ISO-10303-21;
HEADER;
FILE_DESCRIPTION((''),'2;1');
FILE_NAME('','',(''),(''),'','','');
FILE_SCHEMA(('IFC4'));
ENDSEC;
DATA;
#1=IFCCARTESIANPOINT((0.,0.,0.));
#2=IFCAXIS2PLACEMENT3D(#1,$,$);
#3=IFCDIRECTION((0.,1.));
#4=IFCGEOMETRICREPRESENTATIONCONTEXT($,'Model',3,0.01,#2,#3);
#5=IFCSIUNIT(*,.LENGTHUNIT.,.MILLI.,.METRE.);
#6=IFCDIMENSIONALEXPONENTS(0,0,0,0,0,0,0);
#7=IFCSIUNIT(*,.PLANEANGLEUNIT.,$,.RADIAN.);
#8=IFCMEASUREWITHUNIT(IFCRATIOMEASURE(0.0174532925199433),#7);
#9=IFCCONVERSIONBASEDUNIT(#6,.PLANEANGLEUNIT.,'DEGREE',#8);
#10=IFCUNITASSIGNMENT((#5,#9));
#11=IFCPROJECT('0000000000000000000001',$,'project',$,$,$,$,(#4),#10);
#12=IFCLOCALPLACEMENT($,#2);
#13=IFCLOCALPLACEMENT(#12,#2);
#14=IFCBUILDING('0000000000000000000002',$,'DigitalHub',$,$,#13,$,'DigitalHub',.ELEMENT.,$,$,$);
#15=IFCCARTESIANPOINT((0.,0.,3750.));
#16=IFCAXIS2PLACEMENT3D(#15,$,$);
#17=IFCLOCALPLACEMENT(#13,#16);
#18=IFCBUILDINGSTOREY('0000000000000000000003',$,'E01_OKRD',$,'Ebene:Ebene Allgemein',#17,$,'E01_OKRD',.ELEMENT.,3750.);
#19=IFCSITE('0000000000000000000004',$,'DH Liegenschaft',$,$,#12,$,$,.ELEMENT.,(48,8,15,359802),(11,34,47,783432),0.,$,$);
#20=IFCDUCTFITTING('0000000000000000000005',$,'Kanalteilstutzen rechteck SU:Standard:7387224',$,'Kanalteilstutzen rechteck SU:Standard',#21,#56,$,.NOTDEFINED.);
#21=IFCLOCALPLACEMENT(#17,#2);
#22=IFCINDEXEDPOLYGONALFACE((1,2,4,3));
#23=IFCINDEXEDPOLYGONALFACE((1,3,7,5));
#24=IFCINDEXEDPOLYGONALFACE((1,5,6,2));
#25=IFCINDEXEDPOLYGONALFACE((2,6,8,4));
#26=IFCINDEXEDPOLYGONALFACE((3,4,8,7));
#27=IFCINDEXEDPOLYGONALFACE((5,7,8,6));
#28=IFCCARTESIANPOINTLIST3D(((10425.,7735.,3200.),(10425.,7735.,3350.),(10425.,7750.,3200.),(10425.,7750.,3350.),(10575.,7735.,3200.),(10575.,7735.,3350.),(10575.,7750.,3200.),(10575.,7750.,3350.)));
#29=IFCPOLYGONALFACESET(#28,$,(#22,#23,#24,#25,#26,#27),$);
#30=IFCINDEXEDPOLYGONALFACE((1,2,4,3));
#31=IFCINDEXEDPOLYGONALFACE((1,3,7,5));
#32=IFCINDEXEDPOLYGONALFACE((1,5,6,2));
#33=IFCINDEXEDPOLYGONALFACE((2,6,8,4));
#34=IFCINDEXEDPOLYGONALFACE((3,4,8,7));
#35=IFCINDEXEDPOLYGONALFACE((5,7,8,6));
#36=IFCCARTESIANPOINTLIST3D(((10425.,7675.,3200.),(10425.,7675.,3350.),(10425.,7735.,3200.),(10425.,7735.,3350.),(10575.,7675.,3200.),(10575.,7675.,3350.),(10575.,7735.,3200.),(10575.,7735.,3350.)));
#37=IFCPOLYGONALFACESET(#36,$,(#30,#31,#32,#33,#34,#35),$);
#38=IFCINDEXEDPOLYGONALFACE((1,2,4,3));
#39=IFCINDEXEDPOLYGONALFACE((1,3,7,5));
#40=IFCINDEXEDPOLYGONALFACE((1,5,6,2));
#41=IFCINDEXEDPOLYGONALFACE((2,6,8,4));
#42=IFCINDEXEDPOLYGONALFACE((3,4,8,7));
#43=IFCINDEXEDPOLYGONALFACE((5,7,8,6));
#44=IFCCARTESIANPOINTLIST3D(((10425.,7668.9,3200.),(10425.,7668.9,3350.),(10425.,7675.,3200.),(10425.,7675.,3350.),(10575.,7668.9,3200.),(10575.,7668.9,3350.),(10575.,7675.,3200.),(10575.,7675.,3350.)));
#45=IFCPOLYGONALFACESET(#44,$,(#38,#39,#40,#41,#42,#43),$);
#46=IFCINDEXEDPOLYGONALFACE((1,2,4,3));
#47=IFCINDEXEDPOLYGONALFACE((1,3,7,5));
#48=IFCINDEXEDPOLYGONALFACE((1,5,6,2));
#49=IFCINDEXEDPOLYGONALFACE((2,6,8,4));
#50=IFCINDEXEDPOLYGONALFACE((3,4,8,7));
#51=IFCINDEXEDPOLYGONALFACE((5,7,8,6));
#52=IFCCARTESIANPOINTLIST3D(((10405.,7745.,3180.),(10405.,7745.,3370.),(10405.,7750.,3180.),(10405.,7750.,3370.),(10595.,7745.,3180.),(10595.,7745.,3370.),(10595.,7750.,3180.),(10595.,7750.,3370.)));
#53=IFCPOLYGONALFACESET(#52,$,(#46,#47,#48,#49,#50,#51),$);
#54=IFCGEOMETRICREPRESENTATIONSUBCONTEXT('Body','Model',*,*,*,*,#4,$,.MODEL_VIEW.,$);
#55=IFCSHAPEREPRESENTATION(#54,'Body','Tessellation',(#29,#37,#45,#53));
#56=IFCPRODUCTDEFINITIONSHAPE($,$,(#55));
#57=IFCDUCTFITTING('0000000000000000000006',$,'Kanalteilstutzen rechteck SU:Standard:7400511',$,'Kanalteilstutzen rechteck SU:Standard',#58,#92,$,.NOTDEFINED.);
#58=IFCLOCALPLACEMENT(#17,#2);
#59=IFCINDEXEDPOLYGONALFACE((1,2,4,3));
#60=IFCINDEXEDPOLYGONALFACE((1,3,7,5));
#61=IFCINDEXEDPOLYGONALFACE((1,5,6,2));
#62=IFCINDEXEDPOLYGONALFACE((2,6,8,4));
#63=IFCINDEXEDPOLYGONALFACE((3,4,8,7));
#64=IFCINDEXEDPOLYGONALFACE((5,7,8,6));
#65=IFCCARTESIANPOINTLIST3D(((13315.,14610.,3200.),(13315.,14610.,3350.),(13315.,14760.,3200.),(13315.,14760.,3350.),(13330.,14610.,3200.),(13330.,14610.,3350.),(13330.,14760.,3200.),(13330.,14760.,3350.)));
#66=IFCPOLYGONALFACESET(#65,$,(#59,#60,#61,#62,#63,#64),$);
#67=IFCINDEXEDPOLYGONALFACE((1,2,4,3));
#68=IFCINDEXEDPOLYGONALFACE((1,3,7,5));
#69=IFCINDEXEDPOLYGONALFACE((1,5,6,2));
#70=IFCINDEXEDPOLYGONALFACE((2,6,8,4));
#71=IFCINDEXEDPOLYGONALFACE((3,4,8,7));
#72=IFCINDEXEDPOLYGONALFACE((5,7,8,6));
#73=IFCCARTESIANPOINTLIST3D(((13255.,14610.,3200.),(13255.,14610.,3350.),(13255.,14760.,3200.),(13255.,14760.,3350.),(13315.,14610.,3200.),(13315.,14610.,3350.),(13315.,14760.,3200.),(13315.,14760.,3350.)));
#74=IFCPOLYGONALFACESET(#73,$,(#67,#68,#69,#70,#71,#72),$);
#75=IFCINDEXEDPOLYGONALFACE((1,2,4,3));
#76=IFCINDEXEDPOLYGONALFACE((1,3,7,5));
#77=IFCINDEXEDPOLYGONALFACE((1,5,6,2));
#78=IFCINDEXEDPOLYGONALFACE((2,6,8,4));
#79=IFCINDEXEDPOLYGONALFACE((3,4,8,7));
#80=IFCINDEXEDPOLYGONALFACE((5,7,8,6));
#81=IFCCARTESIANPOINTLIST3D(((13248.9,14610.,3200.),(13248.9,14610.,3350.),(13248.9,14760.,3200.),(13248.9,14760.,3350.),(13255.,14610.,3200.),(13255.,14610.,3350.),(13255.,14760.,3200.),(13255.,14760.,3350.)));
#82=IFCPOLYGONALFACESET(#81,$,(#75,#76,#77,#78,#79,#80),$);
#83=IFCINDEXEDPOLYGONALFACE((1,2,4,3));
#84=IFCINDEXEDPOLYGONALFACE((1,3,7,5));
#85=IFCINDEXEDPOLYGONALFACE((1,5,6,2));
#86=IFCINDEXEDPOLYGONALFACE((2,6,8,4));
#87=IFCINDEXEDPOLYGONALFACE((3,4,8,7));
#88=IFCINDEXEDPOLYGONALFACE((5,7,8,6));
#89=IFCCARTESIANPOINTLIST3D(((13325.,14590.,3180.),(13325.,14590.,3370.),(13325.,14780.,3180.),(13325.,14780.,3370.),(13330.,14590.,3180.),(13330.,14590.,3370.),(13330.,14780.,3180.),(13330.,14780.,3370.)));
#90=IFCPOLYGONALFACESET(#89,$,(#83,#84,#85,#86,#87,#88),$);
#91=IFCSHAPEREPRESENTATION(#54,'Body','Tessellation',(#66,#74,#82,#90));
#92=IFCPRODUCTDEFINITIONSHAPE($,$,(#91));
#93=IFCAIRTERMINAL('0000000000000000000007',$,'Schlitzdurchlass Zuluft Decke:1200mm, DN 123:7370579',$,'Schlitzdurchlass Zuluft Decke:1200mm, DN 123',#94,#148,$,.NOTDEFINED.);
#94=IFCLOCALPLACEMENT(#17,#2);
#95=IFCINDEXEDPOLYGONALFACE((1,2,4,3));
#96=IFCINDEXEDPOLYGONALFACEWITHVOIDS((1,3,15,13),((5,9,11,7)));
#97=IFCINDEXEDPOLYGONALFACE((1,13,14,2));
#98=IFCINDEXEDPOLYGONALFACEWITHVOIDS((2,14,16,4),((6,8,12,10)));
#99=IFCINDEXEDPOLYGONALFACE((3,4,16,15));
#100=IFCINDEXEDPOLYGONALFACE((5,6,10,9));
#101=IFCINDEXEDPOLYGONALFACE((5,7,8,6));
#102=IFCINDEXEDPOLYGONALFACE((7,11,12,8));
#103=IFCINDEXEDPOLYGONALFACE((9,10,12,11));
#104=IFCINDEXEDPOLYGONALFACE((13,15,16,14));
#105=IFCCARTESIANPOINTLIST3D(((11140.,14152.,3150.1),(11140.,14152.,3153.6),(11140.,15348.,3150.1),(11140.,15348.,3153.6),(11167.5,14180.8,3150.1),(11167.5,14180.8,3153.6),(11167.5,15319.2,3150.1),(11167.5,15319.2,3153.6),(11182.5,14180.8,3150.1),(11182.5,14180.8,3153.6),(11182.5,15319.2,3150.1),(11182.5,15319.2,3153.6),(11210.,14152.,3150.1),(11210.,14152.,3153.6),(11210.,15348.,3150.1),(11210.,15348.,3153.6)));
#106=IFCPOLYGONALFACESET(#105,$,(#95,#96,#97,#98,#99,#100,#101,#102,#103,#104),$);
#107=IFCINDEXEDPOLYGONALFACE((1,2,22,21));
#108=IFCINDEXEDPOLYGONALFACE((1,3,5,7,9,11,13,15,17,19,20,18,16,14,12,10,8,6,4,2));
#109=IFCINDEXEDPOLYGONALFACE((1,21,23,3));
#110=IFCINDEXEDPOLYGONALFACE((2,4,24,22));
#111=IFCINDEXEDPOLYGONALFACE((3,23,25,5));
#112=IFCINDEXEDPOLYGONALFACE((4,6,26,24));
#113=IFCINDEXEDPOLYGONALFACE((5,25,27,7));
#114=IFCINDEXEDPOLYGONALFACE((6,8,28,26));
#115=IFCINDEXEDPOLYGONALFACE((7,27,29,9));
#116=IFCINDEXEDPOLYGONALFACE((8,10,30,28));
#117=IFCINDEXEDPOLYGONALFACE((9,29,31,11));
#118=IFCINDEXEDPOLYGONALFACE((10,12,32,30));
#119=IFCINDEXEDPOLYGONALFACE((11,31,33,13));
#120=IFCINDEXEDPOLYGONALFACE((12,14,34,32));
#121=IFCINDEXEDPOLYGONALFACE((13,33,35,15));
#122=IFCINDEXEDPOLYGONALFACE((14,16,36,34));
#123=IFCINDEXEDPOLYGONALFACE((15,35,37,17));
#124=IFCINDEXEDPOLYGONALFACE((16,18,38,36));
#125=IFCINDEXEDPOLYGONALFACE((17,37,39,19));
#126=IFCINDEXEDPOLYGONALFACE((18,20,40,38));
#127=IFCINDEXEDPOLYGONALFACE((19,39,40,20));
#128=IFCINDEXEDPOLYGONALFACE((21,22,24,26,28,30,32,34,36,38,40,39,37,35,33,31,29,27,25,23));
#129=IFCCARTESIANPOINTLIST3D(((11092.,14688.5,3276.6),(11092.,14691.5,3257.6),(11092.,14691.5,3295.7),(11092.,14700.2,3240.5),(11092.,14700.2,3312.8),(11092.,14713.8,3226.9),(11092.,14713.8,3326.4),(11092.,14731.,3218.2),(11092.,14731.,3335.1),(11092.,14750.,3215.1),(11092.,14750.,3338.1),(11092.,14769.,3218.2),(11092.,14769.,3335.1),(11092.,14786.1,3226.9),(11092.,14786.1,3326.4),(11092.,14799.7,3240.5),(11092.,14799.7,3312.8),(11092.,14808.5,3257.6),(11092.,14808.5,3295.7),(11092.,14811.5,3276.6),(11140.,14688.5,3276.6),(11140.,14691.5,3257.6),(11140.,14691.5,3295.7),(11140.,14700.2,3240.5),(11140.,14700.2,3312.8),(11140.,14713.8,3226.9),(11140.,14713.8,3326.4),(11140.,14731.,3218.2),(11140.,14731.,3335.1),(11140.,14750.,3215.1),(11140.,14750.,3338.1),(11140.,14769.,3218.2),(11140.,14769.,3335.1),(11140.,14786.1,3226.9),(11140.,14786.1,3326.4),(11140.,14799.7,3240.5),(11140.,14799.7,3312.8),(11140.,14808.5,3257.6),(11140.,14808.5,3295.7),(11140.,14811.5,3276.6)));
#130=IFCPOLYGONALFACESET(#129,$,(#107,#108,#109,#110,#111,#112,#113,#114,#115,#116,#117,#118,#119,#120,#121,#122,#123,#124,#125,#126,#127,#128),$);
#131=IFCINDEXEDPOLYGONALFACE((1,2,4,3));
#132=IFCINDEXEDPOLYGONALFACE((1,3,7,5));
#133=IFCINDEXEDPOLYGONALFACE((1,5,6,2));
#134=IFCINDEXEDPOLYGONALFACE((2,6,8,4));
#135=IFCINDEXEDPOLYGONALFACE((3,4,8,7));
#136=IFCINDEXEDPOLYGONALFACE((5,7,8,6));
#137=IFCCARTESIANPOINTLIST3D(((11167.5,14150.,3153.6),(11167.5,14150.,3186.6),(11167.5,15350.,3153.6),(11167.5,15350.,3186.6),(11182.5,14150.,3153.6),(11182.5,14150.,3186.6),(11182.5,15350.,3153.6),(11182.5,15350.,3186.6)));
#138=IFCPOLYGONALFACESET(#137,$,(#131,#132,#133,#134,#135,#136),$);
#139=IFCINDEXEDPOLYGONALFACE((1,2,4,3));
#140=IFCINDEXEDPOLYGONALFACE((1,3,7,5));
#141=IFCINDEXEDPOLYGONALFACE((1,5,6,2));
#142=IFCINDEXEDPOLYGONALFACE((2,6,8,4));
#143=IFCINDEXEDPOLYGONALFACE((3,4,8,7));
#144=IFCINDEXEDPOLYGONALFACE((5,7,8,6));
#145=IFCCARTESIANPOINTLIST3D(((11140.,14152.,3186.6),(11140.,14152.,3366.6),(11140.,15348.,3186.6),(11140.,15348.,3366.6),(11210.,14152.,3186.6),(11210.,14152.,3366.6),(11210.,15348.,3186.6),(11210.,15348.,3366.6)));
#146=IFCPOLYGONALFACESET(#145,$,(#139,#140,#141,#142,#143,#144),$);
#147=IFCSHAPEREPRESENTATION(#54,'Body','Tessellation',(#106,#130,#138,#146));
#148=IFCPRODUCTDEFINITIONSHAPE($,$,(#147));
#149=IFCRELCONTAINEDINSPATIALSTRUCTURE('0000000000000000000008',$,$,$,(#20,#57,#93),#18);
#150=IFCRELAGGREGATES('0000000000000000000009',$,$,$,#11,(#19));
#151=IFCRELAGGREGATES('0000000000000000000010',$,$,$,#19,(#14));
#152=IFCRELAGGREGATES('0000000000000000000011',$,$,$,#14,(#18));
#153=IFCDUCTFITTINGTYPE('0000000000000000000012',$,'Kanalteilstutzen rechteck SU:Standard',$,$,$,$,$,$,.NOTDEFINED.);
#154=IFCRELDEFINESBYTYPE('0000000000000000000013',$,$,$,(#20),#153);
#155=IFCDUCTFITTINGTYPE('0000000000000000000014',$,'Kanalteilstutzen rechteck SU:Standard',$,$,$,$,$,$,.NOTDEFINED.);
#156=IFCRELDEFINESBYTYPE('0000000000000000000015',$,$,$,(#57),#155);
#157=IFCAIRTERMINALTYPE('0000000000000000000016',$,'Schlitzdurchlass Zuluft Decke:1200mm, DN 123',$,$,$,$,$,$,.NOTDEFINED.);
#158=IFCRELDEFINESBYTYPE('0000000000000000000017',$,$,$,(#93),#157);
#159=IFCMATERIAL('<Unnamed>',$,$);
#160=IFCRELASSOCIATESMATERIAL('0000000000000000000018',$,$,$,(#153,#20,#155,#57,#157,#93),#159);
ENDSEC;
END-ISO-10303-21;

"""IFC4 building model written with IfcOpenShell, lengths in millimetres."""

from ifc_helpers import new_model, entity, si_unit, converted_unit, direction, frame, origin, place, context, subcontext, project, spatial, indexed_curve, outline, extrude, source, transform, mapped, material, type_object, type_shapes, element, save


model = new_model("IFC4")

# Units and contexts
model_context = context("Model", 3, precision=0.01, world=origin(), true_north=direction((0.0, 1.0)))
body_context = subcontext(model_context, "Body", "Model", "MODEL_VIEW")
ifc_project = project(units=[si_unit("LENGTHUNIT", "METRE", prefix="MILLI"), converted_unit("PLANEANGLEUNIT", "DEGREE", entity("IfcRatioMeasure", 0.0174532925199433), si_unit("PLANEANGLEUNIT", "RADIAN"), dimensions=[0, 0, 0, 0, 0, 0, 0])], contexts=[model_context])

# Site, building, storey
site_placement = place(None, origin())
site = spatial("IfcSite", under=ifc_project, at=site_placement, Name="DH Liegenschaft", CompositionType="ELEMENT", RefLatitude=(48, 8, 15, 359802), RefLongitude=(11, 34, 47, 783432), RefElevation=0.0)
building_placement = place(site_placement, origin())
building = spatial("IfcBuilding", under=site, at=building_placement, Name="DigitalHub", LongName="DigitalHub", CompositionType="ELEMENT")
storey_placement = place(building_placement, frame((0.0, 0.0, 3750.0)))
storey = spatial("IfcBuildingStorey", under=building, at=storey_placement, Name="E01_OKRD", ObjectType="Ebene:Ebene Allgemein", LongName="E01_OKRD", CompositionType="ELEMENT", Elevation=3750.0)

# Shared definitions
ifc_material_1 = material(Name="<Unnamed>")

# Duct fittings
duct_fitting_type_1 = type_object("IfcDuctFittingType", Name="Kanalteilstutzen rechteck SU:Standard", PredefinedType="NOTDEFINED", material=ifc_material_1)
shared_shape_1 = source(origin(), body_context, "Body", "SweptSolid", [
    extrude(outline(indexed_curve([(-75.0, -7.5), (75.0, -7.5), (75.0, 7.5), (-75.0, 7.5), (-75.0, -7.5)], self_intersect=False)), frame((67.5, 0.0, -75.0), z_axis=(0.0, 0.0, 1.0), x_axis=(0.0, -1.0, 0.0)), (0.0, 0.0, 1.0), 150.0),
    extrude(outline(indexed_curve([(-75.0, -30.0), (75.0, -30.0), (75.0, 30.0), (-75.0, 30.0), (-75.0, -30.0)], self_intersect=False)), frame((30.0, 0.0, -75.0), z_axis=(0.0, 0.0, 1.0), x_axis=(0.0, -1.0, 0.0)), (0.0, 0.0, 1.0), 150.0),
    extrude(outline(indexed_curve([(-75.0, -3.0), (75.0, -3.0), (75.0, 3.0), (-75.0, 3.0), (-75.0, -3.0)], self_intersect=False)), frame((-3.0, 0.0, -75.0), z_axis=(0.0, 0.0, 1.0), x_axis=(0.0, -1.0, 0.0)), (0.0, 0.0, 1.0), 150.0),
    extrude(outline(indexed_curve([(-95.0, -2.5), (95.0, -2.5), (95.0, 2.5), (-95.0, 2.5), (-95.0, -2.5)], self_intersect=False)), frame((72.5, 0.0, -95.0), z_axis=(0.0, 0.0, 1.0), x_axis=(0.0, -1.0, 0.0)), (0.0, 0.0, 1.0), 190.0),
])
type_shapes(duct_fitting_type_1, [shared_shape_1])
duct_fitting_1_placement = place(storey_placement, frame((10500.0, 7675.0, 3275.0), z_axis=(0.0, 0.0, -1.0), x_axis=(0.0, 1.0, 0.0)))
element("IfcDuctFitting", 1, at=duct_fitting_1_placement, inside=storey, type_object=duct_fitting_type_1, material=ifc_material_1, Name="Kanalteilstutzen rechteck SU:Standard:7387224", ObjectType="Kanalteilstutzen rechteck SU:Standard", PredefinedType="NOTDEFINED", context=body_context, shape_type="MappedRepresentation", body=[
    mapped(shared_shape_1, transform((0.0, 0.0, 0.0), scale=1.0)),
])
duct_fitting_type_2 = type_object("IfcDuctFittingType", Name="Kanalteilstutzen rechteck SU:Standard", PredefinedType="NOTDEFINED", material=ifc_material_1)
shared_shape_2 = source(origin(), body_context, "Body", "SweptSolid", [
    extrude(outline(indexed_curve([(-7.5, -75.0), (7.5, -75.0), (7.5, 75.0), (-7.5, 75.0), (-7.5, -75.0)], self_intersect=False)), frame((67.5, 0.0, -75.0)), (0.0, 0.0, 1.0), 150.0),
    extrude(outline(indexed_curve([(-30.0, -75.0), (30.0, -75.0), (30.0, 75.0), (-30.0, 75.0), (-30.0, -75.0)], self_intersect=False)), frame((30.0, 0.0, -75.0)), (0.0, 0.0, 1.0), 150.0),
    extrude(outline(indexed_curve([(-3.0, -75.0), (3.0, -75.0), (3.0, 75.0), (-3.0, 75.0), (-3.0, -75.0)], self_intersect=False)), frame((-3.0, 0.0, -75.0)), (0.0, 0.0, 1.0), 150.0),
    extrude(outline(indexed_curve([(-2.5, -95.0), (2.5, -95.0), (2.5, 95.0), (-2.5, 95.0), (-2.5, -95.0)], self_intersect=False)), frame((72.5, 0.0, -95.0)), (0.0, 0.0, 1.0), 190.0),
])
type_shapes(duct_fitting_type_2, [shared_shape_2])
duct_fitting_2_placement = place(storey_placement, frame((13255.0, 14685.0, 3275.0), z_axis=(0.0, 0.0, -1.0), x_axis=(1.0, 0.0, 0.0)))
element("IfcDuctFitting", 2, at=duct_fitting_2_placement, inside=storey, type_object=duct_fitting_type_2, material=ifc_material_1, Name="Kanalteilstutzen rechteck SU:Standard:7400511", ObjectType="Kanalteilstutzen rechteck SU:Standard", PredefinedType="NOTDEFINED", context=body_context, shape_type="MappedRepresentation", body=[
    mapped(shared_shape_2, transform((0.0, 0.0, 0.0), scale=1.0)),
])

# Air terminal
air_terminal_type_1 = type_object("IfcAirTerminalType", Name="Schlitzdurchlass Zuluft Decke:1200mm, DN 123", PredefinedType="NOTDEFINED", material=ifc_material_1)
shared_shape_3 = source(origin(), body_context, "Body", "SweptSolid", [
    extrude(outline(indexed_curve([(-598.0, -35.0), (598.0, -35.0), (598.0, 35.0), (-598.0, 35.0), (-598.0, -35.0)], self_intersect=False), holes=[indexed_curve([(-569.2, -7.5), (-569.2, 7.5), (569.2, 7.5), (569.2, -7.5), (-569.2, -7.5)], self_intersect=False)]), frame((600.0, 35.0, 0.0), z_axis=(0.0, 0.0, 1.0), x_axis=(-1.0, 0.0, 0.0)), (0.0, 0.0, 1.0), 3.6),
    extrude(outline(indexed_curve([(61.5, 0.0), (58.5, 19.0), (49.8, 36.1), (36.1, 49.8), (19.0, 58.5), (0.0, 61.5), (-19.0, 58.5), (-36.1, 49.8), (-49.8, 36.1), (-58.5, 19.0), (-61.5, 0.0), (-58.5, -19.0), (-49.8, -36.1), (-36.1, -49.8), (-19.0, -58.5), (0.0, -61.5), (19.0, -58.5), (36.1, -49.8), (49.8, -36.1), (58.5, -19.0), (61.5, 0.0)], self_intersect=False)), frame((600.0, 70.0, 126.6), z_axis=(0.0, 1.0, 0.0), x_axis=(-1.0, 0.0, 0.0)), (0.0, 0.0, 1.0), 48.0),
    extrude(outline(indexed_curve([(-600.0, -7.5), (600.0, -7.5), (600.0, 7.5), (-600.0, 7.5), (-600.0, -7.5)], self_intersect=False)), frame((600.0, 35.0, 3.6), z_axis=(0.0, 0.0, 1.0), x_axis=(-1.0, 0.0, 0.0)), (0.0, 0.0, 1.0), 33.0),
    extrude(outline(indexed_curve([(-598.0, -35.0), (598.0, -35.0), (598.0, 35.0), (-598.0, 35.0), (-598.0, -35.0)], self_intersect=False)), frame((600.0, 35.0, 36.6), z_axis=(0.0, 0.0, 1.0), x_axis=(-1.0, 0.0, 0.0)), (0.0, 0.0, 1.0), 180.0),
])
type_shapes(air_terminal_type_1, [shared_shape_3])
air_terminal_1_placement = place(storey_placement, frame((11210.0, 14150.0, 3150.1), z_axis=(0.0, 0.0, 1.0), x_axis=(0.0, 1.0, 0.0)))
element("IfcAirTerminal", 3, at=air_terminal_1_placement, inside=storey, type_object=air_terminal_type_1, material=ifc_material_1, Name="Schlitzdurchlass Zuluft Decke:1200mm, DN 123:7370579", ObjectType="Schlitzdurchlass Zuluft Decke:1200mm, DN 123", PredefinedType="NOTDEFINED", context=body_context, shape_type="MappedRepresentation", body=[
    mapped(shared_shape_3, transform((0.0, 0.0, 0.0), scale=1.0)),
])

save(model, "model.ifc")
